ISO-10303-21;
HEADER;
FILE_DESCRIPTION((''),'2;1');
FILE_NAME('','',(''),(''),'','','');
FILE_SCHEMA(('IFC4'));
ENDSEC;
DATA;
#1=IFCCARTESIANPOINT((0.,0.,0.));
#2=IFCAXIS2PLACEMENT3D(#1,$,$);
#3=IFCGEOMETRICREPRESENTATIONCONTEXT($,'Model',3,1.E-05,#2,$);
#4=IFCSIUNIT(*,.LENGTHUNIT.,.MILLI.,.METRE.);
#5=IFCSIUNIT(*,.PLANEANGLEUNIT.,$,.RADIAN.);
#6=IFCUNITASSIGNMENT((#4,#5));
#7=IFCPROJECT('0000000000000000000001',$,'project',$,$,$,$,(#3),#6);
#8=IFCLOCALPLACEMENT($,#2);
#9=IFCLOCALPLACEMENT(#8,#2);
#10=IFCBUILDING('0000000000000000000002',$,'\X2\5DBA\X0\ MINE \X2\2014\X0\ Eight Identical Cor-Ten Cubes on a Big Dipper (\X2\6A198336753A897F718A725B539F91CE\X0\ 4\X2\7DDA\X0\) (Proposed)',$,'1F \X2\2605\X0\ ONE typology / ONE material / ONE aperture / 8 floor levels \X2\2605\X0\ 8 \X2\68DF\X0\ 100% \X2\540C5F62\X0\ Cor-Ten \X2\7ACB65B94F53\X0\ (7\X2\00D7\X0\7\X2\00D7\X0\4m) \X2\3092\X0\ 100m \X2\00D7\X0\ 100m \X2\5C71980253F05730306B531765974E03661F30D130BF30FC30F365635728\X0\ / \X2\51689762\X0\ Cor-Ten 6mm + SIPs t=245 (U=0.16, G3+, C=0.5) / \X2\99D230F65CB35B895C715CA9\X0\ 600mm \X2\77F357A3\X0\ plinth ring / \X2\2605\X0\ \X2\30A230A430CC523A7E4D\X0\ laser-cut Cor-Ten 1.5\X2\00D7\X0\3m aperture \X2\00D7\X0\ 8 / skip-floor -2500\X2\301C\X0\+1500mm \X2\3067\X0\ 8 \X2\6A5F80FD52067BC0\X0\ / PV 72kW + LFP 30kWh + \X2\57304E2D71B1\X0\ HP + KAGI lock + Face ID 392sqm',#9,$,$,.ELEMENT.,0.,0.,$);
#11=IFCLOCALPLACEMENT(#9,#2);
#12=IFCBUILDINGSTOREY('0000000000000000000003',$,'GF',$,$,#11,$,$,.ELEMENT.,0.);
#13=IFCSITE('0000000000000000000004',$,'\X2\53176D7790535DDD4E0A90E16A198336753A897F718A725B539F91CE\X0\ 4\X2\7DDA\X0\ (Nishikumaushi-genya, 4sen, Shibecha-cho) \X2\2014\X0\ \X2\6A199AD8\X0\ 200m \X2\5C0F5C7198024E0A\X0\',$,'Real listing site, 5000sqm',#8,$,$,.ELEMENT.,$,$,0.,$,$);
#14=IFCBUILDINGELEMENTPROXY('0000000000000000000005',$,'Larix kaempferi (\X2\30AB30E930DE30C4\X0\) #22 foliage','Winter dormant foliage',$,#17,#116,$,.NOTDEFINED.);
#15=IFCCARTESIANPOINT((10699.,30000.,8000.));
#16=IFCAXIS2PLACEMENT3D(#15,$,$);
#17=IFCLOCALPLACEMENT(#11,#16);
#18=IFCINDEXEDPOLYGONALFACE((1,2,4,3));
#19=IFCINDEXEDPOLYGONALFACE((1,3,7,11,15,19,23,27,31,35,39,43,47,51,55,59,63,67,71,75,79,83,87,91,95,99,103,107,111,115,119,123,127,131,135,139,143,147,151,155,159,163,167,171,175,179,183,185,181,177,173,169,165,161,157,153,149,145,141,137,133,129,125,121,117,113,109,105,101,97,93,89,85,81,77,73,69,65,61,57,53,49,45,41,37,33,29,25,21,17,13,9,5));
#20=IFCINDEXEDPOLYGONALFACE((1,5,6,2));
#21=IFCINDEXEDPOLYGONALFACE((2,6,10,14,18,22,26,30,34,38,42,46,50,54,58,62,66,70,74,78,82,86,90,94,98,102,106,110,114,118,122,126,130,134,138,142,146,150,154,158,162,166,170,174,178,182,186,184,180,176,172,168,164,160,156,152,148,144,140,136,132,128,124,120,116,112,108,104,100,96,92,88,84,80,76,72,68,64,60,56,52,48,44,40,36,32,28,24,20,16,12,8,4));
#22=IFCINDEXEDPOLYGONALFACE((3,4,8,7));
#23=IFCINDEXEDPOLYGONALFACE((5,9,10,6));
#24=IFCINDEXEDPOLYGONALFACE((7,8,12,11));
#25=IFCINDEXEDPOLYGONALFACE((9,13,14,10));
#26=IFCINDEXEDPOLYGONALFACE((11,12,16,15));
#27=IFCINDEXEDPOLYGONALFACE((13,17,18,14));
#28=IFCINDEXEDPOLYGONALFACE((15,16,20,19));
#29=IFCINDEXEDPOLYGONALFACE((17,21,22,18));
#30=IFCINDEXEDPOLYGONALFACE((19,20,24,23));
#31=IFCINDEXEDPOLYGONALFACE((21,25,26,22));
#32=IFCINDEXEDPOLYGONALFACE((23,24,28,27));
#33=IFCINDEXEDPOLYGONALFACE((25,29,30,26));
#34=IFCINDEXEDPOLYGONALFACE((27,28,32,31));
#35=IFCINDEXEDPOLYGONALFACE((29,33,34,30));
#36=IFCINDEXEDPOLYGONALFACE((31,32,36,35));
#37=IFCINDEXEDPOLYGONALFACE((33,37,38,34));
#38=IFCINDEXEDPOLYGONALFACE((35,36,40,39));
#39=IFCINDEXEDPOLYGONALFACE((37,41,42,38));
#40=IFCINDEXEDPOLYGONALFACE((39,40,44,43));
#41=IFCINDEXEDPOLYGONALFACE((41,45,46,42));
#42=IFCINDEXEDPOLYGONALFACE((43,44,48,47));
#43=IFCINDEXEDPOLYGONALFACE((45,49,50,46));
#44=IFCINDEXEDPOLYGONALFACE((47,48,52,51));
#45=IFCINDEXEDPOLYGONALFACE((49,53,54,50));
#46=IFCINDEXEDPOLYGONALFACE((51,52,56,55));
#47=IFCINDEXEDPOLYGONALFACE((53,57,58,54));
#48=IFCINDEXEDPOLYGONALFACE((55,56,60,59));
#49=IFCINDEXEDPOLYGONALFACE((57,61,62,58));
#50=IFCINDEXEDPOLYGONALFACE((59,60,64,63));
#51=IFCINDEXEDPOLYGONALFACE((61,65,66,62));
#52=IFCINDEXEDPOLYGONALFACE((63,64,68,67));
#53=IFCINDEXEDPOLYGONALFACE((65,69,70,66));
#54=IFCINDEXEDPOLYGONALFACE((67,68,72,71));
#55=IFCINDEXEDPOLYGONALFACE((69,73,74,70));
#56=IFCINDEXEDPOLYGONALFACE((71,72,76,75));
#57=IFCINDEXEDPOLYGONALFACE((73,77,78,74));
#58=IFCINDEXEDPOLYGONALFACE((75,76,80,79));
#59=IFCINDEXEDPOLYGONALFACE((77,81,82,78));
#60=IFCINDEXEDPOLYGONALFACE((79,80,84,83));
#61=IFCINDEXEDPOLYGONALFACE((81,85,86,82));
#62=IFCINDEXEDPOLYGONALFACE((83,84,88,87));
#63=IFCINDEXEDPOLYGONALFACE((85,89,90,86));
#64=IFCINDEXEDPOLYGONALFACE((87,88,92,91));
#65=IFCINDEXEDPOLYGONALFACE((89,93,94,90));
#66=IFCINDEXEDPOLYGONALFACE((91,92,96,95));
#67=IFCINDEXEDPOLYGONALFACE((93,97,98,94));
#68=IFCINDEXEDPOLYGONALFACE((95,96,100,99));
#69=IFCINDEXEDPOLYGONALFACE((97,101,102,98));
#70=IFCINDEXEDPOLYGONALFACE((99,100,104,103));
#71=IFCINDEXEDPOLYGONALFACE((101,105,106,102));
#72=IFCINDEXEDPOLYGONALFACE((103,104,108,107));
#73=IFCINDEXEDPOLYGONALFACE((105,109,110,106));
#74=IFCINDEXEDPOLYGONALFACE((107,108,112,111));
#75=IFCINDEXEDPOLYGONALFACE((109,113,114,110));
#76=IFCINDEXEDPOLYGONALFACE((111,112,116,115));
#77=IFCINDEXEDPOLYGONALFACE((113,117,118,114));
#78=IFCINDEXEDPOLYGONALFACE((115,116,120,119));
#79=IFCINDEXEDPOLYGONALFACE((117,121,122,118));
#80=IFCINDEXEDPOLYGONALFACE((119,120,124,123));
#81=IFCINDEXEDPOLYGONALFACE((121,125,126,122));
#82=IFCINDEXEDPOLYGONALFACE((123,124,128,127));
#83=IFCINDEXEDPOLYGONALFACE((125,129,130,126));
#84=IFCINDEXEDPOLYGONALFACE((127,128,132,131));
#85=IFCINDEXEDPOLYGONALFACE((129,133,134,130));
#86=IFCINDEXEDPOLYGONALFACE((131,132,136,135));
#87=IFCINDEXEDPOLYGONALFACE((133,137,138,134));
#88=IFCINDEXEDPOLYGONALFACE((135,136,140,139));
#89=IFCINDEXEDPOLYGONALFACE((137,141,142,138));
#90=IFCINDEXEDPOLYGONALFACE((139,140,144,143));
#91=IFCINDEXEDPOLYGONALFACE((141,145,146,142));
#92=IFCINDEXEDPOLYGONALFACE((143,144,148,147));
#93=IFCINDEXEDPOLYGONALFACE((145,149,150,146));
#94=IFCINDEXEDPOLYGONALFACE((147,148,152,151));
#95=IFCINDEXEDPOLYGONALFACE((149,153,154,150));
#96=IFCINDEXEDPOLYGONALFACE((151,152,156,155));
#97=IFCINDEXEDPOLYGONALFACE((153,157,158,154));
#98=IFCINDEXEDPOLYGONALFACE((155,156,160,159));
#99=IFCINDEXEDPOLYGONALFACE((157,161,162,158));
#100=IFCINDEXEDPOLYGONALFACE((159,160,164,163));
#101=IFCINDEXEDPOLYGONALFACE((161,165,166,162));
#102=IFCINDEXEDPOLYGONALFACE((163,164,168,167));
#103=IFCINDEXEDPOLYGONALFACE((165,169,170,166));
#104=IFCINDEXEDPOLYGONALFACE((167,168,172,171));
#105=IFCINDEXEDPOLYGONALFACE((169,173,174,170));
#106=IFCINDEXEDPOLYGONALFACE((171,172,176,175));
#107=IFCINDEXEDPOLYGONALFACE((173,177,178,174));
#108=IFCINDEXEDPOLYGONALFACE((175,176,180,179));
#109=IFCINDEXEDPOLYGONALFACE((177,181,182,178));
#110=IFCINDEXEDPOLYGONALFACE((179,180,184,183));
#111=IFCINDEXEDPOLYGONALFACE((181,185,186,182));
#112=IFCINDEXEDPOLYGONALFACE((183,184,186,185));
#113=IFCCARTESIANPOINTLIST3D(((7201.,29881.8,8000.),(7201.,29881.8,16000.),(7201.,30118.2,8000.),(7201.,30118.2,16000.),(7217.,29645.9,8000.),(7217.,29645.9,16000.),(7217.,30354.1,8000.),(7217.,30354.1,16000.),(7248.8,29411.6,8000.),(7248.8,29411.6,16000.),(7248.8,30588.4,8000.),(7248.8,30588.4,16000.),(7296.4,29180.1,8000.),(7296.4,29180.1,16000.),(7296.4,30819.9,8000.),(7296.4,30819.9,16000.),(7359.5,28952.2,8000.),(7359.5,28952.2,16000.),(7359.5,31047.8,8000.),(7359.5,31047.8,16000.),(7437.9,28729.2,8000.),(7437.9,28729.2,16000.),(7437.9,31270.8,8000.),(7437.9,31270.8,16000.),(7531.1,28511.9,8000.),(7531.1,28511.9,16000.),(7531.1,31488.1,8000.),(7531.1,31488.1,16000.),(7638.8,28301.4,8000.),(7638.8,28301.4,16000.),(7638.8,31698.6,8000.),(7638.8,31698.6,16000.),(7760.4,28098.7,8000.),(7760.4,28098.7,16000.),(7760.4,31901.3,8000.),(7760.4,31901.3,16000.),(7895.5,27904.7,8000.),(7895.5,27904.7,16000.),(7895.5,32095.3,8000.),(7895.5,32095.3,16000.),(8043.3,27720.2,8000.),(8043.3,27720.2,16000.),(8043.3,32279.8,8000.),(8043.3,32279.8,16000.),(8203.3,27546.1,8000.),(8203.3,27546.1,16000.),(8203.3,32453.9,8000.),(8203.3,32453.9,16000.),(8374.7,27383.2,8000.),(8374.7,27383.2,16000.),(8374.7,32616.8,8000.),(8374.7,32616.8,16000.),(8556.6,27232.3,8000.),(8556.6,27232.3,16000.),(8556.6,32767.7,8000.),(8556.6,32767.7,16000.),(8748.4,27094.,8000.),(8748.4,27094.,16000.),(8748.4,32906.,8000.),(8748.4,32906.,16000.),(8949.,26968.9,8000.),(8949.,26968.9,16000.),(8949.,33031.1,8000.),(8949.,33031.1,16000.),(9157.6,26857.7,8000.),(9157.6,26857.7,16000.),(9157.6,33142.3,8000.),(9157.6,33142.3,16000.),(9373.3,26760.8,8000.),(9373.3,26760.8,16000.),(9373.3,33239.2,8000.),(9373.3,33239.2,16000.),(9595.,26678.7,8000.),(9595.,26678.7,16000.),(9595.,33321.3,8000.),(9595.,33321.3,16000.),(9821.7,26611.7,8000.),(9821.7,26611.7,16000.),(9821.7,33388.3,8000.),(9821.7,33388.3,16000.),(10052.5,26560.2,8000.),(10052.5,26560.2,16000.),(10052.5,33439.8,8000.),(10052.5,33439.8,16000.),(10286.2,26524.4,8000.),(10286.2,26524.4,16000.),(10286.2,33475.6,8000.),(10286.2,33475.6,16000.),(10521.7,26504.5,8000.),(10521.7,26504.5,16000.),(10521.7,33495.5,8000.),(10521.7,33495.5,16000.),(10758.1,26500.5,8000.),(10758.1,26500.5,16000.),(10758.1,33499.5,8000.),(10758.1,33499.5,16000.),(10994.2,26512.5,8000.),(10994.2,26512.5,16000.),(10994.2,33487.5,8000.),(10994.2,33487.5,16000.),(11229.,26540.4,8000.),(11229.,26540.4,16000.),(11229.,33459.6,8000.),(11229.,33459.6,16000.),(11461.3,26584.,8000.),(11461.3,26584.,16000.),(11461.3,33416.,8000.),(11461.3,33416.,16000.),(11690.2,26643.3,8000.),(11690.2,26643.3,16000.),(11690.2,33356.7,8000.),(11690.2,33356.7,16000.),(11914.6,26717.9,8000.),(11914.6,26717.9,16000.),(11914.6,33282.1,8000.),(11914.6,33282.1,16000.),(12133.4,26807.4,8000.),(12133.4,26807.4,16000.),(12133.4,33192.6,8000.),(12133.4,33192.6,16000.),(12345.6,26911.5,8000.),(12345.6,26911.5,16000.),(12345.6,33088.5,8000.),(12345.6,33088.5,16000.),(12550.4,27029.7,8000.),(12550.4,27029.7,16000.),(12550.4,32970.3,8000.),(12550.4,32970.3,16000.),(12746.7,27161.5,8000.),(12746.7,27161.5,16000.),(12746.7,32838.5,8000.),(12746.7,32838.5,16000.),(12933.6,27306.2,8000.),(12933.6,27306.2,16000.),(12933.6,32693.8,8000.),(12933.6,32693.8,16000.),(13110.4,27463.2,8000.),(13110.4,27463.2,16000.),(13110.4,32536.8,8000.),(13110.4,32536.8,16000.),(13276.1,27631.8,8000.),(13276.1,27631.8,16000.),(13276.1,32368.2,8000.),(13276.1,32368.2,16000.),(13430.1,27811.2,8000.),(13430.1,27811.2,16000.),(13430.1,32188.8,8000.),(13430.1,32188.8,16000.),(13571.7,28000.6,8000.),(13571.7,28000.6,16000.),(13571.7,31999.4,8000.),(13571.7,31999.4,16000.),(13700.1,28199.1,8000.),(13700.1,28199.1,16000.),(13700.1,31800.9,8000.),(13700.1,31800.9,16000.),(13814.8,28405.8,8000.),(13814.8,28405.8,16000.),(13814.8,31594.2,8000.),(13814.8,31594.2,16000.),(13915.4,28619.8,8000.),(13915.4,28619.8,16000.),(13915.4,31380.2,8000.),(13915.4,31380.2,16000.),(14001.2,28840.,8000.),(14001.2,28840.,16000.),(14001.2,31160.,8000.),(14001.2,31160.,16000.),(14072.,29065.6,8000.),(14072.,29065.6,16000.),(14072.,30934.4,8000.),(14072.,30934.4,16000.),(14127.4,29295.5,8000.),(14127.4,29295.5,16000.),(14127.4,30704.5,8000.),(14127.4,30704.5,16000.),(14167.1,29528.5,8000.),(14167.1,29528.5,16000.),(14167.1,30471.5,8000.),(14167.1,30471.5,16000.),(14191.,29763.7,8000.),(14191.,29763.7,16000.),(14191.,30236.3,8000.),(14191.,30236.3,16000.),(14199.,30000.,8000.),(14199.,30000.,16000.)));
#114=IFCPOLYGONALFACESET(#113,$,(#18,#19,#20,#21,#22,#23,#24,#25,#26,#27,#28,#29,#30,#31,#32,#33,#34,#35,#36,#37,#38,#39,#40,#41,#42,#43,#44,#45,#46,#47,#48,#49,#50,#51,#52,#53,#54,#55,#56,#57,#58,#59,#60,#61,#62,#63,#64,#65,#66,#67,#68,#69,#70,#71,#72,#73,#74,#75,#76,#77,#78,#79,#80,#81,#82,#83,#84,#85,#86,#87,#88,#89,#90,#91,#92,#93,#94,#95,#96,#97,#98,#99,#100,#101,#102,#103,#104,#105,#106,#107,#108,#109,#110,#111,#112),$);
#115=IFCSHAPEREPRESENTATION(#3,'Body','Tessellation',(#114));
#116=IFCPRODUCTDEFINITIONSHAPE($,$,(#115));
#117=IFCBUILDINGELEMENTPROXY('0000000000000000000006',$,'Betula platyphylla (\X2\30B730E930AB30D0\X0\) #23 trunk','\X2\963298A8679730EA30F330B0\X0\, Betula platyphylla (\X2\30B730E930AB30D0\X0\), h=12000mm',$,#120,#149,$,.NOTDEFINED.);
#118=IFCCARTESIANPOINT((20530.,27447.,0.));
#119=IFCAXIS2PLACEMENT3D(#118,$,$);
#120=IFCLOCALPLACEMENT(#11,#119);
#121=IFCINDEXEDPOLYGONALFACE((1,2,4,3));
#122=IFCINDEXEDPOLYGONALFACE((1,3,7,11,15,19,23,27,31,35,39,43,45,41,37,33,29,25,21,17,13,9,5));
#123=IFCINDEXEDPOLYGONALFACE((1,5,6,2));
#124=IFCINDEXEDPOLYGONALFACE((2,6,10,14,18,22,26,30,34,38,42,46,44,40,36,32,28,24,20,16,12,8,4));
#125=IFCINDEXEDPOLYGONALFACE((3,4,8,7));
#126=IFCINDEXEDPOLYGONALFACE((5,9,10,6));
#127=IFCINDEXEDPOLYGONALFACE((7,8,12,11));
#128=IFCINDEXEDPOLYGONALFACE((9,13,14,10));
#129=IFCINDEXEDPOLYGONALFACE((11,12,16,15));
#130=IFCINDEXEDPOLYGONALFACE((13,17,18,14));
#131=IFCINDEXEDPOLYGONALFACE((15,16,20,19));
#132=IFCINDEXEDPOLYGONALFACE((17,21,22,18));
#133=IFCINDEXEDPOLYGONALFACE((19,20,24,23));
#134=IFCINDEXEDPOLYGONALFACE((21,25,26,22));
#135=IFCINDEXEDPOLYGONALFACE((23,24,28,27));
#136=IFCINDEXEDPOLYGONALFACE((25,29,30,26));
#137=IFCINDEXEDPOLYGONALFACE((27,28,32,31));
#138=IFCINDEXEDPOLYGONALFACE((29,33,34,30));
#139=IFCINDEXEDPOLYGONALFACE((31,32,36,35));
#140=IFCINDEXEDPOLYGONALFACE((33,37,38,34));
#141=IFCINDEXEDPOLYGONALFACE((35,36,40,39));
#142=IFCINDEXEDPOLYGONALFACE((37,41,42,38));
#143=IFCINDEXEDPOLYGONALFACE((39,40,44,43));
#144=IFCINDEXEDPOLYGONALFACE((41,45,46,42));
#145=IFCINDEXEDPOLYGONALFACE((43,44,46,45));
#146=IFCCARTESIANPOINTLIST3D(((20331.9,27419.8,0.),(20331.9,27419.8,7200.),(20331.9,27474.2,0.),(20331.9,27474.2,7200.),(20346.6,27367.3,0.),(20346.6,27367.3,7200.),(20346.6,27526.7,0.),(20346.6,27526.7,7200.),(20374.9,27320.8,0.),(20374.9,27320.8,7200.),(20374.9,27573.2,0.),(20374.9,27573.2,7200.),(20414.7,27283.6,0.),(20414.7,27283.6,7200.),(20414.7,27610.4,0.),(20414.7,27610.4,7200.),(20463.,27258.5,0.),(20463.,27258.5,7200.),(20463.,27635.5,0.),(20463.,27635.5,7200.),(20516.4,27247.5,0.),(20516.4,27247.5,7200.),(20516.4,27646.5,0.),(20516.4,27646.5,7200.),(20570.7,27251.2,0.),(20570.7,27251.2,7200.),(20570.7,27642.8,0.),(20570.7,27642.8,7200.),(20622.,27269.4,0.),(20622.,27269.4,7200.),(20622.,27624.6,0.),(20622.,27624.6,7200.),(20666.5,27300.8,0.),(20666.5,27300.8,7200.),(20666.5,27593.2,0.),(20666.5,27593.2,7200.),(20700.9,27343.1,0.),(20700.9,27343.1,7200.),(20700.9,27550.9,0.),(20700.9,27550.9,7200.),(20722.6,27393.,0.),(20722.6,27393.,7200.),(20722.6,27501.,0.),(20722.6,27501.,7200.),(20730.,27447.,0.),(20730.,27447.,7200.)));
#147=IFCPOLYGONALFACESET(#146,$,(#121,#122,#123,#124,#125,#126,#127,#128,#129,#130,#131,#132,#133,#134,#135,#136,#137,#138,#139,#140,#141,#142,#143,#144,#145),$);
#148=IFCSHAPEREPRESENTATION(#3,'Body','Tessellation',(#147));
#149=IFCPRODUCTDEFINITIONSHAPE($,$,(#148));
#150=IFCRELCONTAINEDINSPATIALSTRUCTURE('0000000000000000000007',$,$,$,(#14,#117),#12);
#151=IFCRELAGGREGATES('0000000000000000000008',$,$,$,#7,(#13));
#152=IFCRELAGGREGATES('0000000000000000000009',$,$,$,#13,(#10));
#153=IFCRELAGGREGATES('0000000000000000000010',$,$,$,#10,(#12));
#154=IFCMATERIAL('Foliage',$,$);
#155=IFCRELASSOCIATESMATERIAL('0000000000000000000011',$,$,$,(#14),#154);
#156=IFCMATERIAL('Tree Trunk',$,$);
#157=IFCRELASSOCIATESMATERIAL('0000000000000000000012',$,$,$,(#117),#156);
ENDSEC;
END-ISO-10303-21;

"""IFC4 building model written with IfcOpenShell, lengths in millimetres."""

from ifc_helpers import new_model, si_unit, frame, origin, origin_2d, place, context, project, spatial, circle, extrude, material, element, save


model = new_model("IFC4")

# Units and contexts
model_context = context("Model", 3, precision=1e-05, world=origin())
ifc_project = project(units=[si_unit("LENGTHUNIT", "METRE", prefix="MILLI"), si_unit("PLANEANGLEUNIT", "RADIAN")], contexts=[model_context])

# Site, building, storey
site_placement = place(None, origin())
site = spatial("IfcSite", under=ifc_project, at=site_placement, Name="北海道川上郡標茶町西熊牛原野 4線 (Nishikumaushi-genya, 4sen, Shibecha-cho) — 標高 200m 小山頂上", ObjectType="Real listing site, 5000sqm", CompositionType="ELEMENT", RefElevation=0.0)
building_placement = place(site_placement, origin())
building = spatial("IfcBuilding", under=site, at=building_placement, Name="嶺 MINE — Eight Identical Cor-Ten Cubes on a Big Dipper (標茶町西熊牛原野 4線) (Proposed)", ObjectType="1F ★ ONE typology / ONE material / ONE aperture / 8 floor levels ★ 8 棟 100% 同形 Cor-Ten 立方体 (7×7×4m) を 100m × 100m 山頂台地に北斗七星パターン散在 / 全面 Cor-Ten 6mm + SIPs t=245 (U=0.16, G3+, C=0.5) / 駒ヶ岳安山岩 600mm 石垣 plinth ring / ★ アイヌ刺繍 laser-cut Cor-Ten 1.5×3m aperture × 8 / skip-floor -2500〜+1500mm で 8 機能分節 / PV 72kW + LFP 30kWh + 地中熱 HP + KAGI lock + Face ID 392sqm", CompositionType="ELEMENT", ElevationOfRefHeight=0.0, ElevationOfTerrain=0.0)
storey_placement = place(building_placement, origin())
storey = spatial("IfcBuildingStorey", under=building, at=storey_placement, Name="GF", CompositionType="ELEMENT", Elevation=0.0)

# Building element proxies
ifc_material_1 = material(Name="Tree Trunk")
ifc_material_2 = material(Name="Foliage")
proxy_1_placement = place(storey_placement, frame((10699.0, 30000.0, 8000.0)))
element("IfcBuildingElementProxy", 1, at=proxy_1_placement, inside=storey, material=ifc_material_2, Name="Larix kaempferi (カラマツ) #22 foliage", Description="Winter dormant foliage", PredefinedType="NOTDEFINED", context=model_context, shape_type="SweptSolid", body=[
    extrude(circle(Radius=3500.0, at=origin_2d()), frame((10699.0, 30000.0, 8000.0)), (0.0, 0.0, 1.0), 8000.0),
])
proxy_2_placement = place(storey_placement, frame((20530.0, 27447.0, 0.0)))
element("IfcBuildingElementProxy", 2, at=proxy_2_placement, inside=storey, material=ifc_material_1, Name="Betula platyphylla (シラカバ) #23 trunk", Description="防風林リング, Betula platyphylla (シラカバ), h=12000mm", PredefinedType="NOTDEFINED", context=model_context, shape_type="SweptSolid", body=[
    extrude(circle(Radius=200.0, at=origin_2d()), frame((20530.0, 27447.0, 0.0)), (0.0, 0.0, 1.0), 7200.0),
])

save(model, "model.ifc")
